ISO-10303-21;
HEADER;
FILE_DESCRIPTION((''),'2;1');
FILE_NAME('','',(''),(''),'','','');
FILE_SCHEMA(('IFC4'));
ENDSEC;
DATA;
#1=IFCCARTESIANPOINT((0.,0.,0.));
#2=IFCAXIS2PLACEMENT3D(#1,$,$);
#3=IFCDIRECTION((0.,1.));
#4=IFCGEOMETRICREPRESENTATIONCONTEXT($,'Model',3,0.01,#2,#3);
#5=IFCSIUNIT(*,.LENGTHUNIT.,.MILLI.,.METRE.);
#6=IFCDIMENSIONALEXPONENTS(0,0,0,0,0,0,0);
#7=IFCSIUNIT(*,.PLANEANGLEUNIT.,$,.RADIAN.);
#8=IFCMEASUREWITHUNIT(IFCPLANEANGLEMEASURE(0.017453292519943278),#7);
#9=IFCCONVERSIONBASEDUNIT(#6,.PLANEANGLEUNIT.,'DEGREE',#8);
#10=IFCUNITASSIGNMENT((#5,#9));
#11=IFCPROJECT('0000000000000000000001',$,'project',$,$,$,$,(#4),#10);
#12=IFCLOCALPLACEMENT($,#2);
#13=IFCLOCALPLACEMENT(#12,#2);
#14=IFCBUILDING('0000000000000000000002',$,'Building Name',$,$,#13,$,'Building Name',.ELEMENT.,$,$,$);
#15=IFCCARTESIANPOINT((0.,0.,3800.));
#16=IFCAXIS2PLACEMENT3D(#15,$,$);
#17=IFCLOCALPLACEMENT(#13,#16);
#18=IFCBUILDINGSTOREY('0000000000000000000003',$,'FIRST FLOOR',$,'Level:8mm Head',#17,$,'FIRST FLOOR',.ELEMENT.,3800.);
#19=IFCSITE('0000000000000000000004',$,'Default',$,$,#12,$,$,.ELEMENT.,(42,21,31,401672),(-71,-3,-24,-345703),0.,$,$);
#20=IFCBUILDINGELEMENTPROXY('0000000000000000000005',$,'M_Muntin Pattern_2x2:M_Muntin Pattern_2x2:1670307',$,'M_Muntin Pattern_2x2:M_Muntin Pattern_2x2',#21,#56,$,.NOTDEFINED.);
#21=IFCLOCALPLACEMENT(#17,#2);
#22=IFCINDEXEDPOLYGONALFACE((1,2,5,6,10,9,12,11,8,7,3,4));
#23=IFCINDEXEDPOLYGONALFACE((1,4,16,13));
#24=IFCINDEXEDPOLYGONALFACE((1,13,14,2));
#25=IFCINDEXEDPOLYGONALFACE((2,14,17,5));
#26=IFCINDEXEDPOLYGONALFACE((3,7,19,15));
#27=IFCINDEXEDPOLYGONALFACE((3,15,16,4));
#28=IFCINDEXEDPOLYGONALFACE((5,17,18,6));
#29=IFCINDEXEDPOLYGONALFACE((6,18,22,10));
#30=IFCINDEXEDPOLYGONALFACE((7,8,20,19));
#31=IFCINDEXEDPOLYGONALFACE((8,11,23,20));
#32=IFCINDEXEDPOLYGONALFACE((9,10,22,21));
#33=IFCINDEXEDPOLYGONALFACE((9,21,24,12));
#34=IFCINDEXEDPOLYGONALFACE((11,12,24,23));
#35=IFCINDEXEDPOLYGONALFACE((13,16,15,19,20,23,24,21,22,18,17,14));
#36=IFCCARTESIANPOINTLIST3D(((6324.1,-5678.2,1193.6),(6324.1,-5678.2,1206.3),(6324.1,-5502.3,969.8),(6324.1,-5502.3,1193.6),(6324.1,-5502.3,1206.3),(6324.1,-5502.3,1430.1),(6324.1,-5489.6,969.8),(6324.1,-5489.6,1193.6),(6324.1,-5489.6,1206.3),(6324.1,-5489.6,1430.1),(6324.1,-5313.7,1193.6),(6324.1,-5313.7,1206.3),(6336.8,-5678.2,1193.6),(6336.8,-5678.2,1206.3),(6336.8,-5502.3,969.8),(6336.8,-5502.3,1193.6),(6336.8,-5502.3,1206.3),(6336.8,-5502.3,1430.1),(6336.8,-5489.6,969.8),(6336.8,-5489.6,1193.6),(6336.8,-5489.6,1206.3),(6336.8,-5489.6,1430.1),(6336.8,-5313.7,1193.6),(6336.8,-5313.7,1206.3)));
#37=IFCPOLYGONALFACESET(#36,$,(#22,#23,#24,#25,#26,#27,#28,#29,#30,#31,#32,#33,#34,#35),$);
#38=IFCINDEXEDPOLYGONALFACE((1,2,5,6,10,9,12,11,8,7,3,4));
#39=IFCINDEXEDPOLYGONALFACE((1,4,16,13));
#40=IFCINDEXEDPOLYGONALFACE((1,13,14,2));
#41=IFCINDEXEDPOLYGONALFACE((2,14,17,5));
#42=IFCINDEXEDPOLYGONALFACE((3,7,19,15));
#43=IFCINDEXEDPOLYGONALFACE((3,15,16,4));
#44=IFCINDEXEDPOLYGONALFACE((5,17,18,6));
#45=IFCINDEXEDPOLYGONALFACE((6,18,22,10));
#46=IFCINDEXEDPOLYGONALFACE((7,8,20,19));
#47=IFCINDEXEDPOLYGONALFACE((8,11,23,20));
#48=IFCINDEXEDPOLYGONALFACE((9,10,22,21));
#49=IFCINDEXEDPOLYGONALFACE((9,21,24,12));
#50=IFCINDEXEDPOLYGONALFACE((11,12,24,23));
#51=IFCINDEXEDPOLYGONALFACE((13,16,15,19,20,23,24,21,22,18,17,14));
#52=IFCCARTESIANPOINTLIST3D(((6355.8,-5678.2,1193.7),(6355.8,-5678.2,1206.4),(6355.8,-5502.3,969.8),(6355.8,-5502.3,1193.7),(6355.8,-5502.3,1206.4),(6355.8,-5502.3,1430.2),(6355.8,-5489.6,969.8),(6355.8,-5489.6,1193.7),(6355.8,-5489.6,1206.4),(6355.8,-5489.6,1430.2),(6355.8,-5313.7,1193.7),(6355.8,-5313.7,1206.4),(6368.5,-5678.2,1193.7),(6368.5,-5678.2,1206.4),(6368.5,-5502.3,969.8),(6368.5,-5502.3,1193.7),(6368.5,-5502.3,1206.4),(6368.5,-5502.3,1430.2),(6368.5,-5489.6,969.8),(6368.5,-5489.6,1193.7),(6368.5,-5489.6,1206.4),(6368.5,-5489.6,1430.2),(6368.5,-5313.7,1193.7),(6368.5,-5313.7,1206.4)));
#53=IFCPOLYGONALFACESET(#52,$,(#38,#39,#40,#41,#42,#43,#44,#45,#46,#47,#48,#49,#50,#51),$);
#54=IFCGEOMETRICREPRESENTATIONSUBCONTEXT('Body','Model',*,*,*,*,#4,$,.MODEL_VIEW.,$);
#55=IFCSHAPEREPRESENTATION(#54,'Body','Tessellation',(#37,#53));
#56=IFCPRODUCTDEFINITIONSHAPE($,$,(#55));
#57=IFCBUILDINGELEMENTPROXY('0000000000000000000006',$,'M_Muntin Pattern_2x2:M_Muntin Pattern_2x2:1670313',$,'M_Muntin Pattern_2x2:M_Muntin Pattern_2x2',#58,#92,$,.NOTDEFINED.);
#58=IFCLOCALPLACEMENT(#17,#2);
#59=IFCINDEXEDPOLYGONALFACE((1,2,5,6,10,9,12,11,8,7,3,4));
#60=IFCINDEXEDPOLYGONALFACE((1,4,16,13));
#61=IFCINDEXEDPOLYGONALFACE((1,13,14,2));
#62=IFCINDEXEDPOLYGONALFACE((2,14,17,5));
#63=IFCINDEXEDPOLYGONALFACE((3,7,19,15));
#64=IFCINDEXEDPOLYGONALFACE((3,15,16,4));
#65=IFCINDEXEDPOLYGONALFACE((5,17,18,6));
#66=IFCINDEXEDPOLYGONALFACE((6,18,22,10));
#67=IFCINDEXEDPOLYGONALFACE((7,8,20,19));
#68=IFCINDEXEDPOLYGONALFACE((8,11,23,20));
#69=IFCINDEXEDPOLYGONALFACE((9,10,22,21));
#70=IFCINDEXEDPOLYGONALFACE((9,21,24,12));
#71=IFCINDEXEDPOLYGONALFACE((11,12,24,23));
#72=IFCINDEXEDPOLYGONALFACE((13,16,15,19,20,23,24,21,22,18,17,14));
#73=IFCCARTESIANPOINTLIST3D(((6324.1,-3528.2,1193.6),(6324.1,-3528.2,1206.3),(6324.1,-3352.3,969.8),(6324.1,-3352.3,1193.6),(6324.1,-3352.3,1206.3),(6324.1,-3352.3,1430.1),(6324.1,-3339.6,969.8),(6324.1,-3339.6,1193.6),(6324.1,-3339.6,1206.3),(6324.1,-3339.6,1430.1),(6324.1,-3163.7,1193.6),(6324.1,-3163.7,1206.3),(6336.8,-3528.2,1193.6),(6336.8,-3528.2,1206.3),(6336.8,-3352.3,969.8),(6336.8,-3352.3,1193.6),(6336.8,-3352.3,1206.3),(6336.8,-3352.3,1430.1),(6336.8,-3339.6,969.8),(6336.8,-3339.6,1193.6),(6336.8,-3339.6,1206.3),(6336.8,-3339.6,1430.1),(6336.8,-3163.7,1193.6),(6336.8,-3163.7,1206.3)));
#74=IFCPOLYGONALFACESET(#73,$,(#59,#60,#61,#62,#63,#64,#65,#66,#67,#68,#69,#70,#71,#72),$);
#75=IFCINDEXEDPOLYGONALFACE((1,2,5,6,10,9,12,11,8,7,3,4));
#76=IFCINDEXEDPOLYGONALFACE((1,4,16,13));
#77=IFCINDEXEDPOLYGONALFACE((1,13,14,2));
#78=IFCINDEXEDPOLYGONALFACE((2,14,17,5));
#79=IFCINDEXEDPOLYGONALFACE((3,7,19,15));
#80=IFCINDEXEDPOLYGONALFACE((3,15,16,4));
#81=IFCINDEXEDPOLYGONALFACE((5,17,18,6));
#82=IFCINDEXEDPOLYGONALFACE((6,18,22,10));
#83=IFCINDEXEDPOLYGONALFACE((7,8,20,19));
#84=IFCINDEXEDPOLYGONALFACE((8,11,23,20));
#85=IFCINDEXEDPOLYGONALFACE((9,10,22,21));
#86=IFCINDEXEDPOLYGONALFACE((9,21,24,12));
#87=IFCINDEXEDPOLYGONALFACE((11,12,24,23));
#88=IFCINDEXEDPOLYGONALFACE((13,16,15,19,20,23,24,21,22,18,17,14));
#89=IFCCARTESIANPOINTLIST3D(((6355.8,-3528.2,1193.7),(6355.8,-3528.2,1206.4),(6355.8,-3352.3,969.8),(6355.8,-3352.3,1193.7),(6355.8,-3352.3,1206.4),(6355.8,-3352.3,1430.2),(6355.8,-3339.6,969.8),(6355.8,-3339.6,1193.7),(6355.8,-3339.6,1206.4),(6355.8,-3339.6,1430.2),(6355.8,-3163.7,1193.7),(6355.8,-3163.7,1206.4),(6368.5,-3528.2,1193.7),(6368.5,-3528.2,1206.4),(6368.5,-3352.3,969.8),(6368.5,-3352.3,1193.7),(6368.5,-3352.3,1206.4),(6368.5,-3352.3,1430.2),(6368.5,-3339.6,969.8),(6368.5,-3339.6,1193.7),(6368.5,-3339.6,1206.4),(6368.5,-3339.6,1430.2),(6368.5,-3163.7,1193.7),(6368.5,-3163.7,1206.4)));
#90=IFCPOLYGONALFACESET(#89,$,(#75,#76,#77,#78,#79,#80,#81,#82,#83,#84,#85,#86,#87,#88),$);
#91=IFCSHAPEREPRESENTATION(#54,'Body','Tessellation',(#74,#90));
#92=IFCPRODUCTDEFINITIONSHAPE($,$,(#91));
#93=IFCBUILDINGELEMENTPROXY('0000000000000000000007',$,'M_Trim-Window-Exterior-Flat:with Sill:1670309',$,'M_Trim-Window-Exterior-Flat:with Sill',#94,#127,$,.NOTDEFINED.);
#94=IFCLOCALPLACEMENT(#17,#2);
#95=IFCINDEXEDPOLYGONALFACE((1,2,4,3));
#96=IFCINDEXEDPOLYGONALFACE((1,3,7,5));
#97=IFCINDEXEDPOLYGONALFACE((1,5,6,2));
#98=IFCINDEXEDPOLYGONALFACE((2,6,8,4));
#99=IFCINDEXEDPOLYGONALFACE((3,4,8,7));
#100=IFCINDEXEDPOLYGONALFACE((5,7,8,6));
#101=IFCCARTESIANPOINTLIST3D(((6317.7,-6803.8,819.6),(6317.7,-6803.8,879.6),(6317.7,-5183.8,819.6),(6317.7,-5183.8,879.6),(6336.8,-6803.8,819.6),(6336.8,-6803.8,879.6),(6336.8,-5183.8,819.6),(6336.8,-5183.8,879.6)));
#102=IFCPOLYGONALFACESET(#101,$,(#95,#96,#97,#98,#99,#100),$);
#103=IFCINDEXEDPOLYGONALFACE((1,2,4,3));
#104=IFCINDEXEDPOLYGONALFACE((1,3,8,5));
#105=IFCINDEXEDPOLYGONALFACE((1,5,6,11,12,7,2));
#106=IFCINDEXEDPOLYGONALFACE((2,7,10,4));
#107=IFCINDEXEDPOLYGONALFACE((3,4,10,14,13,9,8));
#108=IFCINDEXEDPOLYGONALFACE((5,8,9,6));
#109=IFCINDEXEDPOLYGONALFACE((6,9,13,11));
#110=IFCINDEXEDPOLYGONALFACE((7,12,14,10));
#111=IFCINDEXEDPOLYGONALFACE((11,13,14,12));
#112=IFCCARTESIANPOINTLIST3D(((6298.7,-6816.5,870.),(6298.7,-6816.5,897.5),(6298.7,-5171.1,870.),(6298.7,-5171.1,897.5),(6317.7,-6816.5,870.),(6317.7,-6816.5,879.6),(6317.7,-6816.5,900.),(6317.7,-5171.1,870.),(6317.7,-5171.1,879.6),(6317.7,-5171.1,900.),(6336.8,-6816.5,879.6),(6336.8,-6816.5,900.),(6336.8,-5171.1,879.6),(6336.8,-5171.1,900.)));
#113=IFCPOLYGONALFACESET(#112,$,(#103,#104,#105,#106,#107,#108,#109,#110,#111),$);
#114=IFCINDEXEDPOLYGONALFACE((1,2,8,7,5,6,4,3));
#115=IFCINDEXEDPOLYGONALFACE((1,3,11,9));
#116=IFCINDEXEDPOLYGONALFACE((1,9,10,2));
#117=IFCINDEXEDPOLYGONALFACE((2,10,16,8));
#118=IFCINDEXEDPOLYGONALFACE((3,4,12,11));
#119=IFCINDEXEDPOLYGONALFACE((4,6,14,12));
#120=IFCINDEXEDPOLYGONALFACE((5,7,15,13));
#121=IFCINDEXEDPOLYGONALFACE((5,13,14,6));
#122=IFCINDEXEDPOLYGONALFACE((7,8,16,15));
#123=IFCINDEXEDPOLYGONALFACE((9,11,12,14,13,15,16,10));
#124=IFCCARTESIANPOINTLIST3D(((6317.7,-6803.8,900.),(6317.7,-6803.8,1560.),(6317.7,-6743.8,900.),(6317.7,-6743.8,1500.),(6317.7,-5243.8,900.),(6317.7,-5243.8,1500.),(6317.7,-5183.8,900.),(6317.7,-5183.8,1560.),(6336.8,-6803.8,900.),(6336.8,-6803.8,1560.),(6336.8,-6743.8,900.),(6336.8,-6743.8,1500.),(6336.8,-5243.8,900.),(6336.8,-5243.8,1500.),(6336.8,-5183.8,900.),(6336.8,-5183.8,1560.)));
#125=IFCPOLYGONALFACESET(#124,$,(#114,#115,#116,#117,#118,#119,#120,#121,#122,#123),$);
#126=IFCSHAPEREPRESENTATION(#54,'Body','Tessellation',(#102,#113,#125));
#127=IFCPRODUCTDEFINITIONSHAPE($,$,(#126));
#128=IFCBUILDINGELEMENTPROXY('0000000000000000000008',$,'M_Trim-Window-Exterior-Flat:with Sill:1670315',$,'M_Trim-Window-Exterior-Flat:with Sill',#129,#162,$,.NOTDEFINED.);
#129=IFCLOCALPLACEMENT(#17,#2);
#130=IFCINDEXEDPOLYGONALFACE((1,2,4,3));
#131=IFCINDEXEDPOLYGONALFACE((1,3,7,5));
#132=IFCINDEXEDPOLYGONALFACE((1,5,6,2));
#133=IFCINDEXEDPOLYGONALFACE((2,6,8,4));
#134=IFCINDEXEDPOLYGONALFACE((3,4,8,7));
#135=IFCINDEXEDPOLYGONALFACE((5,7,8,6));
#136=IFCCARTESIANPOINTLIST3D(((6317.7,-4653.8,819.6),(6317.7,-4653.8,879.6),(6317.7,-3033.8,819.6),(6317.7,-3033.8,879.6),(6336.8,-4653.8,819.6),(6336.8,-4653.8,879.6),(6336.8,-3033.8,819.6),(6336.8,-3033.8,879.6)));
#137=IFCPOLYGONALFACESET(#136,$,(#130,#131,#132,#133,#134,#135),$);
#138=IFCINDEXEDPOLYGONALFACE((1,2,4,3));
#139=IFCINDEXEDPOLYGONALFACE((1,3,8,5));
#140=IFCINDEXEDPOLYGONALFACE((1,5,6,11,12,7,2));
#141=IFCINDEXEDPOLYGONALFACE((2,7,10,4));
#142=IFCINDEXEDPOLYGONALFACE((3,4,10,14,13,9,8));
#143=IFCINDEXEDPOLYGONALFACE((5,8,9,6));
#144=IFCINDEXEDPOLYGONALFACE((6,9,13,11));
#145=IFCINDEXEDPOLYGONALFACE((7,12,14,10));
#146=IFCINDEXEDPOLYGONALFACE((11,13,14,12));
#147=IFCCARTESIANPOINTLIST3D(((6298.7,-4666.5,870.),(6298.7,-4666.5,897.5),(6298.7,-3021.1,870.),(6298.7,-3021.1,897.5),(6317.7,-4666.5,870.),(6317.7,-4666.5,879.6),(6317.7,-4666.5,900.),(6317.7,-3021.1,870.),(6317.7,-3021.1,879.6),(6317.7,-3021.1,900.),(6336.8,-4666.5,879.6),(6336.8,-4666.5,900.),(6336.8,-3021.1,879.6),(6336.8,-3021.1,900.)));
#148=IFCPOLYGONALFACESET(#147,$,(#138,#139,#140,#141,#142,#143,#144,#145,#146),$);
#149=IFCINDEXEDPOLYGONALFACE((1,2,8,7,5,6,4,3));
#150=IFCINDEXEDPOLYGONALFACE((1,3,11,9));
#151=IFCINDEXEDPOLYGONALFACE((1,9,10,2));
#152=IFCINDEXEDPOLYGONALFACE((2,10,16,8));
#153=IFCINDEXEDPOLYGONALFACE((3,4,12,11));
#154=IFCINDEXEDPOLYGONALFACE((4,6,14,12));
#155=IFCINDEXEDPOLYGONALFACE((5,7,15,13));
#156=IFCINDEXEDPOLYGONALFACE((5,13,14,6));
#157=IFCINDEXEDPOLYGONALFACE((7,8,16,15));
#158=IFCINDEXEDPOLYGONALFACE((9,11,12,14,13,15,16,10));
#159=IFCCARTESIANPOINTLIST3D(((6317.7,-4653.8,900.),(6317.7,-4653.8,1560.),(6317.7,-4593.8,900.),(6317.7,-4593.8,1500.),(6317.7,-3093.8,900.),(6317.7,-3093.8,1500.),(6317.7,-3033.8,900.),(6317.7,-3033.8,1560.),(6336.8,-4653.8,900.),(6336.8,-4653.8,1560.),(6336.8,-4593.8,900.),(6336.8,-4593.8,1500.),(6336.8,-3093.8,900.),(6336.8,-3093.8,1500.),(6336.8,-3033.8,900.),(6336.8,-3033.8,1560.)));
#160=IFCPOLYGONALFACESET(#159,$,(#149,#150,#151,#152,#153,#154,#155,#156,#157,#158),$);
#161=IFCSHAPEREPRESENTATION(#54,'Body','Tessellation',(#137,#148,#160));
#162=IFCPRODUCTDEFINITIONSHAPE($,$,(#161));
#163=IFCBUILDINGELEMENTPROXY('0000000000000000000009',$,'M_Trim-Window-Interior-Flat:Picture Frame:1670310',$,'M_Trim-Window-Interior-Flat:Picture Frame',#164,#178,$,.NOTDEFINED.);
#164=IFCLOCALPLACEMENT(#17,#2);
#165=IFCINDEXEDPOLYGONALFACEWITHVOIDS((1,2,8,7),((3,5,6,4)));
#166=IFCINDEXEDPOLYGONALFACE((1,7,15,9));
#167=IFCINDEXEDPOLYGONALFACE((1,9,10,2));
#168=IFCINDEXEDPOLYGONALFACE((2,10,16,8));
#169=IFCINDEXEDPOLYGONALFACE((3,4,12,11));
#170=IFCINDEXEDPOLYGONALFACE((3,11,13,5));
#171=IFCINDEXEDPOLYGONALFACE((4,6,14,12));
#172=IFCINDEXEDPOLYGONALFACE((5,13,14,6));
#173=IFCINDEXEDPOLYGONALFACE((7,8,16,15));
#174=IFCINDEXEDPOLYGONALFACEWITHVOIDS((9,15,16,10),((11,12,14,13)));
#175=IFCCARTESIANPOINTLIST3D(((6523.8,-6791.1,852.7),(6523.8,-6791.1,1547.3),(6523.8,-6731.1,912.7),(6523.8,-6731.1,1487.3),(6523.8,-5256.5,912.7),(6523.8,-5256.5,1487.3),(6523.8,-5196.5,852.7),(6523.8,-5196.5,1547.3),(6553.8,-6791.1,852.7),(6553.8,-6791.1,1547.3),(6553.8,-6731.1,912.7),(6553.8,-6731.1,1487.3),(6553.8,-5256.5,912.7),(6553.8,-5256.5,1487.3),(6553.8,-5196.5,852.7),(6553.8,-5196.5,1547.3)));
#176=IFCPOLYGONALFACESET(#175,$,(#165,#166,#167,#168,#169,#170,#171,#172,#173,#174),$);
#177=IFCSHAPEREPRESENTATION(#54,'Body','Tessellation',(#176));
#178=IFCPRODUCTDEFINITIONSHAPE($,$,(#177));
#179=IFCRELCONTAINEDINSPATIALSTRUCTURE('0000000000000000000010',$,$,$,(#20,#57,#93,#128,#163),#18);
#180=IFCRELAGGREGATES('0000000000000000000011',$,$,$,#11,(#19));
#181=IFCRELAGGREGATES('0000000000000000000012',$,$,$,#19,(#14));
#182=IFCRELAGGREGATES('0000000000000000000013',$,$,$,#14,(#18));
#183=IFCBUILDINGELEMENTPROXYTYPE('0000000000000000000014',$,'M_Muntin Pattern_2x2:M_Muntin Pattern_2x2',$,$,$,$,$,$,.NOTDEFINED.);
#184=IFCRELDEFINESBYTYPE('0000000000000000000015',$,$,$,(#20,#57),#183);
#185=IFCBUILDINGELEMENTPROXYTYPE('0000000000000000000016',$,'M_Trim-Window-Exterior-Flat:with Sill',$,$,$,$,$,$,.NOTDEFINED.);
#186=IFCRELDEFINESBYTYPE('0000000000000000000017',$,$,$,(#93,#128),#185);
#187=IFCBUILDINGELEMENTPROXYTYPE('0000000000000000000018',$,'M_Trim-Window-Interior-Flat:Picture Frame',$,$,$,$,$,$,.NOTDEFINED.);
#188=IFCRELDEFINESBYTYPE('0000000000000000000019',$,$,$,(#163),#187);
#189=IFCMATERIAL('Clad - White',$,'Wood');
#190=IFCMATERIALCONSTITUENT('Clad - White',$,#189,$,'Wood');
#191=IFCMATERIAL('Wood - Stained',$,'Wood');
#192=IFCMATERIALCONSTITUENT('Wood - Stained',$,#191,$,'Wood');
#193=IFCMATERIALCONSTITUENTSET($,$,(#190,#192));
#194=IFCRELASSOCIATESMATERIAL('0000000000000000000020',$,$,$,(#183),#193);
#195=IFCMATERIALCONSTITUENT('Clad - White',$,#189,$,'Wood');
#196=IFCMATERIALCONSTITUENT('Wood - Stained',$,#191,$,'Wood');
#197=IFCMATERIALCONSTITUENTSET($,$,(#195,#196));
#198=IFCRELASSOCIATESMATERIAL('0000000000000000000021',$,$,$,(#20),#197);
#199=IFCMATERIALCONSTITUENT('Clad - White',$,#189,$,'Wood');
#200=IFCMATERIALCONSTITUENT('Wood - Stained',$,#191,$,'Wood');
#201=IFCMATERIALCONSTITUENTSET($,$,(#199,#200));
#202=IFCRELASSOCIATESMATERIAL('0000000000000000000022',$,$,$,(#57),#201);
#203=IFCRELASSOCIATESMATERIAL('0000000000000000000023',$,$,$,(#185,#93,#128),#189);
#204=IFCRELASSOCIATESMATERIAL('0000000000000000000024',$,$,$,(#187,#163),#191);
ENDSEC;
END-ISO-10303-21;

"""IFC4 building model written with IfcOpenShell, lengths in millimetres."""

from ifc_helpers import new_model, entity, si_unit, converted_unit, direction, frame, origin, place, context, subcontext, project, spatial, indexed_curve, outline, extrude, source, transform, mapped, material, constituent, constituent_set, type_object, type_shapes, element, save


model = new_model("IFC4")

# Units and contexts
model_context = context("Model", 3, precision=0.01, world=origin(), true_north=direction((0.0, 1.0)))
body_context = subcontext(model_context, "Body", "Model", "MODEL_VIEW")
ifc_project = project(units=[si_unit("LENGTHUNIT", "METRE", prefix="MILLI"), converted_unit("PLANEANGLEUNIT", "DEGREE", entity("IfcPlaneAngleMeasure", 0.017453292519943278), si_unit("PLANEANGLEUNIT", "RADIAN"), dimensions=[0, 0, 0, 0, 0, 0, 0])], contexts=[model_context])

# Site, building, storey
site_placement = place(None, origin())
site = spatial("IfcSite", under=ifc_project, at=site_placement, Name="Default", CompositionType="ELEMENT", RefLatitude=(42, 21, 31, 401672), RefLongitude=(-71, -3, -24, -345703), RefElevation=0.0)
building_placement = place(site_placement, origin())
building = spatial("IfcBuilding", under=site, at=building_placement, Name="Building Name", LongName="Building Name", CompositionType="ELEMENT")
storey_placement = place(building_placement, frame((0.0, 0.0, 3800.0)))
storey = spatial("IfcBuildingStorey", under=building, at=storey_placement, Name="FIRST FLOOR", ObjectType="Level:8mm Head", LongName="FIRST FLOOR", CompositionType="ELEMENT", Elevation=3800.0)

# Shared definitions
ifc_material_1 = material(Name="Wood - Stained", Category="Wood")

# Building element proxies
ifc_material_2 = material(Name="Clad - White", Category="Wood")
ifc_constituent_1 = constituent(ifc_material_2, Name="Clad - White", Category="Wood")
ifc_constituent_2 = constituent(ifc_material_1, Name="Wood - Stained", Category="Wood")
ifc_constituent_set_1 = constituent_set(constituents=[ifc_constituent_1, ifc_constituent_2])
ifc_constituent_3 = constituent(ifc_material_2, Name="Clad - White", Category="Wood")
ifc_constituent_4 = constituent(ifc_material_1, Name="Wood - Stained", Category="Wood")
ifc_constituent_set_2 = constituent_set(constituents=[ifc_constituent_3, ifc_constituent_4])
building_element_proxy_type_1 = type_object("IfcBuildingElementProxyType", Name="M_Muntin Pattern_2x2:M_Muntin Pattern_2x2", PredefinedType="NOTDEFINED", material=ifc_constituent_set_2)
shared_shape_1 = source(origin(), body_context, "Body", "SweptSolid", [
    extrude(outline(indexed_curve([(6.4, -6.4), (230.1, -6.4), (230.1, 6.3), (6.4, 6.3), (6.4, 182.3), (-6.3, 182.3), (-6.3, 6.3), (-230.2, 6.3), (-230.2, -6.4), (-6.3, -6.4), (-6.3, -182.3), (6.4, -182.3), (6.4, -6.4)], self_intersect=False)), frame((0.0, -22.2, 230.1), z_axis=(0.0, 1.0, 0.0), x_axis=(0.0, 0.0, 1.0)), (0.0, 0.0, 1.0), 12.7),
    extrude(outline(indexed_curve([(6.4, -6.4), (230.2, -6.4), (230.2, 6.3), (6.4, 6.3), (6.4, 182.3), (-6.3, 182.3), (-6.3, 6.3), (-230.2, 6.3), (-230.2, -6.4), (-6.3, -6.4), (-6.3, -182.3), (6.4, -182.3), (6.4, -6.4)], self_intersect=False)), frame((0.0, 9.5, 230.2), z_axis=(0.0, 1.0, 0.0), x_axis=(0.0, 0.0, 1.0)), (0.0, 0.0, 1.0), 12.7),
])
type_shapes(building_element_proxy_type_1, [shared_shape_1])
proxy_1_placement = place(storey_placement, frame((6346.3, -5495.9, 969.8), z_axis=(0.0, 0.0, 1.0), x_axis=(0.0, -1.0, 0.0)))
element("IfcBuildingElementProxy", 1, at=proxy_1_placement, inside=storey, type_object=building_element_proxy_type_1, material=ifc_constituent_set_1, Name="M_Muntin Pattern_2x2:M_Muntin Pattern_2x2:1670307", ObjectType="M_Muntin Pattern_2x2:M_Muntin Pattern_2x2", PredefinedType="NOTDEFINED", context=body_context, shape_type="MappedRepresentation", body=[
    mapped(shared_shape_1, transform((0.0, 0.0, 0.0), scale=1.0)),
])
ifc_constituent_5 = constituent(ifc_material_2, Name="Clad - White", Category="Wood")
ifc_constituent_6 = constituent(ifc_material_1, Name="Wood - Stained", Category="Wood")
ifc_constituent_set_3 = constituent_set(constituents=[ifc_constituent_5, ifc_constituent_6])
proxy_2_placement = place(storey_placement, frame((6346.3, -3345.9, 969.8), z_axis=(0.0, 0.0, 1.0), x_axis=(0.0, -1.0, 0.0)))
element("IfcBuildingElementProxy", 2, at=proxy_2_placement, inside=storey, type_object=building_element_proxy_type_1, material=ifc_constituent_set_3, Name="M_Muntin Pattern_2x2:M_Muntin Pattern_2x2:1670313", ObjectType="M_Muntin Pattern_2x2:M_Muntin Pattern_2x2", PredefinedType="NOTDEFINED", context=body_context, shape_type="MappedRepresentation", body=[
    mapped(shared_shape_1, transform((0.0, 0.0, 0.0), scale=1.0)),
])
building_element_proxy_type_2 = type_object("IfcBuildingElementProxyType", Name="M_Trim-Window-Exterior-Flat:with Sill", PredefinedType="NOTDEFINED", material=ifc_material_2)
shared_shape_2 = source(origin(), body_context, "Body", "SweptSolid", [
    extrude(outline(indexed_curve([(-30.0, -810.0), (30.0, -810.0), (30.0, 810.0), (-30.0, 810.0), (-30.0, -810.0)], self_intersect=False)), frame((0.0, 650.4, 0.0), z_axis=(0.0, 0.0, 1.0), x_axis=(0.0, 1.0, 0.0)), (0.0, 0.0, 1.0), 19.0),
    extrude(outline(indexed_curve([(-15.2, -19.0), (12.3, -19.0), (14.8, 0.0), (14.8, 19.0), (-5.7, 19.0), (-5.7, 0.0), (-15.2, 0.0), (-15.2, -19.0)], self_intersect=False)), frame((-822.7, 614.8, 19.0), z_axis=(1.0, 0.0, 0.0), x_axis=(0.0, -1.0, 0.0)), (0.0, 0.0, 1.0), 1645.4),
    extrude(outline(indexed_curve([(-810.0, -345.0), (810.0, -345.0), (810.0, 315.0), (750.0, 315.0), (750.0, -285.0), (-750.0, -285.0), (-750.0, 315.0), (-810.0, 315.0), (-810.0, -345.0)], self_intersect=False)), frame((0.0, 285.0, 0.0)), (0.0, 0.0, 1.0), 19.0),
])
type_shapes(building_element_proxy_type_2, [shared_shape_2])
for number, where, z_axis, x_axis, name in (
    (3, (6336.8, -5993.8, 1500.0), (-1.0, 0.0, 0.0), (0.0, 1.0, 0.0), "M_Trim-Window-Exterior-Flat:with Sill:1670309"),
    (4, (6336.8, -3843.8, 1500.0), (-1.0, 0.0, 0.0), (0.0, 1.0, 0.0), "M_Trim-Window-Exterior-Flat:with Sill:1670315"),
):
    element("IfcBuildingElementProxy", number, at=place(storey_placement, frame(where, z_axis=z_axis, x_axis=x_axis)), inside=storey, type_object=building_element_proxy_type_2, material=ifc_material_2, Name=name, ObjectType="M_Trim-Window-Exterior-Flat:with Sill", PredefinedType="NOTDEFINED", context=body_context, shape_type="MappedRepresentation", body=[
        mapped(shared_shape_2, transform((0.0, 0.0, 0.0), scale=1.0)),
    ])
building_element_proxy_type_3 = type_object("IfcBuildingElementProxyType", Name="M_Trim-Window-Interior-Flat:Picture Frame", PredefinedType="NOTDEFINED", material=ifc_material_1)
shared_shape_3 = source(origin(), body_context, "Body", "SweptSolid", [
    extrude(outline(indexed_curve([(-347.3, -797.3), (347.3, -797.3), (347.3, 797.3), (-347.3, 797.3), (-347.3, -797.3)], self_intersect=False), holes=[indexed_curve([(-287.3, -737.3), (-287.3, 737.3), (287.3, 737.3), (287.3, -737.3), (-287.3, -737.3)], self_intersect=False)]), frame((0.0, 300.0, 0.0), z_axis=(0.0, 0.0, 1.0), x_axis=(0.0, 1.0, 0.0)), (0.0, 0.0, 1.0), 30.0),
])
type_shapes(building_element_proxy_type_3, [shared_shape_3])
for number, where, z_axis, x_axis, name in (
    (5, (6523.8, -5993.8, 1500.0), (1.0, 0.0, 0.0), (0.0, -1.0, 0.0), "M_Trim-Window-Interior-Flat:Picture Frame:1670310"),
):
    element("IfcBuildingElementProxy", number, at=place(storey_placement, frame(where, z_axis=z_axis, x_axis=x_axis)), inside=storey, type_object=building_element_proxy_type_3, material=ifc_material_1, Name=name, ObjectType="M_Trim-Window-Interior-Flat:Picture Frame", PredefinedType="NOTDEFINED", context=body_context, shape_type="MappedRepresentation", body=[
        mapped(shared_shape_3, transform((0.0, 0.0, 0.0), scale=1.0)),
    ])

save(model, "model.ifc")
